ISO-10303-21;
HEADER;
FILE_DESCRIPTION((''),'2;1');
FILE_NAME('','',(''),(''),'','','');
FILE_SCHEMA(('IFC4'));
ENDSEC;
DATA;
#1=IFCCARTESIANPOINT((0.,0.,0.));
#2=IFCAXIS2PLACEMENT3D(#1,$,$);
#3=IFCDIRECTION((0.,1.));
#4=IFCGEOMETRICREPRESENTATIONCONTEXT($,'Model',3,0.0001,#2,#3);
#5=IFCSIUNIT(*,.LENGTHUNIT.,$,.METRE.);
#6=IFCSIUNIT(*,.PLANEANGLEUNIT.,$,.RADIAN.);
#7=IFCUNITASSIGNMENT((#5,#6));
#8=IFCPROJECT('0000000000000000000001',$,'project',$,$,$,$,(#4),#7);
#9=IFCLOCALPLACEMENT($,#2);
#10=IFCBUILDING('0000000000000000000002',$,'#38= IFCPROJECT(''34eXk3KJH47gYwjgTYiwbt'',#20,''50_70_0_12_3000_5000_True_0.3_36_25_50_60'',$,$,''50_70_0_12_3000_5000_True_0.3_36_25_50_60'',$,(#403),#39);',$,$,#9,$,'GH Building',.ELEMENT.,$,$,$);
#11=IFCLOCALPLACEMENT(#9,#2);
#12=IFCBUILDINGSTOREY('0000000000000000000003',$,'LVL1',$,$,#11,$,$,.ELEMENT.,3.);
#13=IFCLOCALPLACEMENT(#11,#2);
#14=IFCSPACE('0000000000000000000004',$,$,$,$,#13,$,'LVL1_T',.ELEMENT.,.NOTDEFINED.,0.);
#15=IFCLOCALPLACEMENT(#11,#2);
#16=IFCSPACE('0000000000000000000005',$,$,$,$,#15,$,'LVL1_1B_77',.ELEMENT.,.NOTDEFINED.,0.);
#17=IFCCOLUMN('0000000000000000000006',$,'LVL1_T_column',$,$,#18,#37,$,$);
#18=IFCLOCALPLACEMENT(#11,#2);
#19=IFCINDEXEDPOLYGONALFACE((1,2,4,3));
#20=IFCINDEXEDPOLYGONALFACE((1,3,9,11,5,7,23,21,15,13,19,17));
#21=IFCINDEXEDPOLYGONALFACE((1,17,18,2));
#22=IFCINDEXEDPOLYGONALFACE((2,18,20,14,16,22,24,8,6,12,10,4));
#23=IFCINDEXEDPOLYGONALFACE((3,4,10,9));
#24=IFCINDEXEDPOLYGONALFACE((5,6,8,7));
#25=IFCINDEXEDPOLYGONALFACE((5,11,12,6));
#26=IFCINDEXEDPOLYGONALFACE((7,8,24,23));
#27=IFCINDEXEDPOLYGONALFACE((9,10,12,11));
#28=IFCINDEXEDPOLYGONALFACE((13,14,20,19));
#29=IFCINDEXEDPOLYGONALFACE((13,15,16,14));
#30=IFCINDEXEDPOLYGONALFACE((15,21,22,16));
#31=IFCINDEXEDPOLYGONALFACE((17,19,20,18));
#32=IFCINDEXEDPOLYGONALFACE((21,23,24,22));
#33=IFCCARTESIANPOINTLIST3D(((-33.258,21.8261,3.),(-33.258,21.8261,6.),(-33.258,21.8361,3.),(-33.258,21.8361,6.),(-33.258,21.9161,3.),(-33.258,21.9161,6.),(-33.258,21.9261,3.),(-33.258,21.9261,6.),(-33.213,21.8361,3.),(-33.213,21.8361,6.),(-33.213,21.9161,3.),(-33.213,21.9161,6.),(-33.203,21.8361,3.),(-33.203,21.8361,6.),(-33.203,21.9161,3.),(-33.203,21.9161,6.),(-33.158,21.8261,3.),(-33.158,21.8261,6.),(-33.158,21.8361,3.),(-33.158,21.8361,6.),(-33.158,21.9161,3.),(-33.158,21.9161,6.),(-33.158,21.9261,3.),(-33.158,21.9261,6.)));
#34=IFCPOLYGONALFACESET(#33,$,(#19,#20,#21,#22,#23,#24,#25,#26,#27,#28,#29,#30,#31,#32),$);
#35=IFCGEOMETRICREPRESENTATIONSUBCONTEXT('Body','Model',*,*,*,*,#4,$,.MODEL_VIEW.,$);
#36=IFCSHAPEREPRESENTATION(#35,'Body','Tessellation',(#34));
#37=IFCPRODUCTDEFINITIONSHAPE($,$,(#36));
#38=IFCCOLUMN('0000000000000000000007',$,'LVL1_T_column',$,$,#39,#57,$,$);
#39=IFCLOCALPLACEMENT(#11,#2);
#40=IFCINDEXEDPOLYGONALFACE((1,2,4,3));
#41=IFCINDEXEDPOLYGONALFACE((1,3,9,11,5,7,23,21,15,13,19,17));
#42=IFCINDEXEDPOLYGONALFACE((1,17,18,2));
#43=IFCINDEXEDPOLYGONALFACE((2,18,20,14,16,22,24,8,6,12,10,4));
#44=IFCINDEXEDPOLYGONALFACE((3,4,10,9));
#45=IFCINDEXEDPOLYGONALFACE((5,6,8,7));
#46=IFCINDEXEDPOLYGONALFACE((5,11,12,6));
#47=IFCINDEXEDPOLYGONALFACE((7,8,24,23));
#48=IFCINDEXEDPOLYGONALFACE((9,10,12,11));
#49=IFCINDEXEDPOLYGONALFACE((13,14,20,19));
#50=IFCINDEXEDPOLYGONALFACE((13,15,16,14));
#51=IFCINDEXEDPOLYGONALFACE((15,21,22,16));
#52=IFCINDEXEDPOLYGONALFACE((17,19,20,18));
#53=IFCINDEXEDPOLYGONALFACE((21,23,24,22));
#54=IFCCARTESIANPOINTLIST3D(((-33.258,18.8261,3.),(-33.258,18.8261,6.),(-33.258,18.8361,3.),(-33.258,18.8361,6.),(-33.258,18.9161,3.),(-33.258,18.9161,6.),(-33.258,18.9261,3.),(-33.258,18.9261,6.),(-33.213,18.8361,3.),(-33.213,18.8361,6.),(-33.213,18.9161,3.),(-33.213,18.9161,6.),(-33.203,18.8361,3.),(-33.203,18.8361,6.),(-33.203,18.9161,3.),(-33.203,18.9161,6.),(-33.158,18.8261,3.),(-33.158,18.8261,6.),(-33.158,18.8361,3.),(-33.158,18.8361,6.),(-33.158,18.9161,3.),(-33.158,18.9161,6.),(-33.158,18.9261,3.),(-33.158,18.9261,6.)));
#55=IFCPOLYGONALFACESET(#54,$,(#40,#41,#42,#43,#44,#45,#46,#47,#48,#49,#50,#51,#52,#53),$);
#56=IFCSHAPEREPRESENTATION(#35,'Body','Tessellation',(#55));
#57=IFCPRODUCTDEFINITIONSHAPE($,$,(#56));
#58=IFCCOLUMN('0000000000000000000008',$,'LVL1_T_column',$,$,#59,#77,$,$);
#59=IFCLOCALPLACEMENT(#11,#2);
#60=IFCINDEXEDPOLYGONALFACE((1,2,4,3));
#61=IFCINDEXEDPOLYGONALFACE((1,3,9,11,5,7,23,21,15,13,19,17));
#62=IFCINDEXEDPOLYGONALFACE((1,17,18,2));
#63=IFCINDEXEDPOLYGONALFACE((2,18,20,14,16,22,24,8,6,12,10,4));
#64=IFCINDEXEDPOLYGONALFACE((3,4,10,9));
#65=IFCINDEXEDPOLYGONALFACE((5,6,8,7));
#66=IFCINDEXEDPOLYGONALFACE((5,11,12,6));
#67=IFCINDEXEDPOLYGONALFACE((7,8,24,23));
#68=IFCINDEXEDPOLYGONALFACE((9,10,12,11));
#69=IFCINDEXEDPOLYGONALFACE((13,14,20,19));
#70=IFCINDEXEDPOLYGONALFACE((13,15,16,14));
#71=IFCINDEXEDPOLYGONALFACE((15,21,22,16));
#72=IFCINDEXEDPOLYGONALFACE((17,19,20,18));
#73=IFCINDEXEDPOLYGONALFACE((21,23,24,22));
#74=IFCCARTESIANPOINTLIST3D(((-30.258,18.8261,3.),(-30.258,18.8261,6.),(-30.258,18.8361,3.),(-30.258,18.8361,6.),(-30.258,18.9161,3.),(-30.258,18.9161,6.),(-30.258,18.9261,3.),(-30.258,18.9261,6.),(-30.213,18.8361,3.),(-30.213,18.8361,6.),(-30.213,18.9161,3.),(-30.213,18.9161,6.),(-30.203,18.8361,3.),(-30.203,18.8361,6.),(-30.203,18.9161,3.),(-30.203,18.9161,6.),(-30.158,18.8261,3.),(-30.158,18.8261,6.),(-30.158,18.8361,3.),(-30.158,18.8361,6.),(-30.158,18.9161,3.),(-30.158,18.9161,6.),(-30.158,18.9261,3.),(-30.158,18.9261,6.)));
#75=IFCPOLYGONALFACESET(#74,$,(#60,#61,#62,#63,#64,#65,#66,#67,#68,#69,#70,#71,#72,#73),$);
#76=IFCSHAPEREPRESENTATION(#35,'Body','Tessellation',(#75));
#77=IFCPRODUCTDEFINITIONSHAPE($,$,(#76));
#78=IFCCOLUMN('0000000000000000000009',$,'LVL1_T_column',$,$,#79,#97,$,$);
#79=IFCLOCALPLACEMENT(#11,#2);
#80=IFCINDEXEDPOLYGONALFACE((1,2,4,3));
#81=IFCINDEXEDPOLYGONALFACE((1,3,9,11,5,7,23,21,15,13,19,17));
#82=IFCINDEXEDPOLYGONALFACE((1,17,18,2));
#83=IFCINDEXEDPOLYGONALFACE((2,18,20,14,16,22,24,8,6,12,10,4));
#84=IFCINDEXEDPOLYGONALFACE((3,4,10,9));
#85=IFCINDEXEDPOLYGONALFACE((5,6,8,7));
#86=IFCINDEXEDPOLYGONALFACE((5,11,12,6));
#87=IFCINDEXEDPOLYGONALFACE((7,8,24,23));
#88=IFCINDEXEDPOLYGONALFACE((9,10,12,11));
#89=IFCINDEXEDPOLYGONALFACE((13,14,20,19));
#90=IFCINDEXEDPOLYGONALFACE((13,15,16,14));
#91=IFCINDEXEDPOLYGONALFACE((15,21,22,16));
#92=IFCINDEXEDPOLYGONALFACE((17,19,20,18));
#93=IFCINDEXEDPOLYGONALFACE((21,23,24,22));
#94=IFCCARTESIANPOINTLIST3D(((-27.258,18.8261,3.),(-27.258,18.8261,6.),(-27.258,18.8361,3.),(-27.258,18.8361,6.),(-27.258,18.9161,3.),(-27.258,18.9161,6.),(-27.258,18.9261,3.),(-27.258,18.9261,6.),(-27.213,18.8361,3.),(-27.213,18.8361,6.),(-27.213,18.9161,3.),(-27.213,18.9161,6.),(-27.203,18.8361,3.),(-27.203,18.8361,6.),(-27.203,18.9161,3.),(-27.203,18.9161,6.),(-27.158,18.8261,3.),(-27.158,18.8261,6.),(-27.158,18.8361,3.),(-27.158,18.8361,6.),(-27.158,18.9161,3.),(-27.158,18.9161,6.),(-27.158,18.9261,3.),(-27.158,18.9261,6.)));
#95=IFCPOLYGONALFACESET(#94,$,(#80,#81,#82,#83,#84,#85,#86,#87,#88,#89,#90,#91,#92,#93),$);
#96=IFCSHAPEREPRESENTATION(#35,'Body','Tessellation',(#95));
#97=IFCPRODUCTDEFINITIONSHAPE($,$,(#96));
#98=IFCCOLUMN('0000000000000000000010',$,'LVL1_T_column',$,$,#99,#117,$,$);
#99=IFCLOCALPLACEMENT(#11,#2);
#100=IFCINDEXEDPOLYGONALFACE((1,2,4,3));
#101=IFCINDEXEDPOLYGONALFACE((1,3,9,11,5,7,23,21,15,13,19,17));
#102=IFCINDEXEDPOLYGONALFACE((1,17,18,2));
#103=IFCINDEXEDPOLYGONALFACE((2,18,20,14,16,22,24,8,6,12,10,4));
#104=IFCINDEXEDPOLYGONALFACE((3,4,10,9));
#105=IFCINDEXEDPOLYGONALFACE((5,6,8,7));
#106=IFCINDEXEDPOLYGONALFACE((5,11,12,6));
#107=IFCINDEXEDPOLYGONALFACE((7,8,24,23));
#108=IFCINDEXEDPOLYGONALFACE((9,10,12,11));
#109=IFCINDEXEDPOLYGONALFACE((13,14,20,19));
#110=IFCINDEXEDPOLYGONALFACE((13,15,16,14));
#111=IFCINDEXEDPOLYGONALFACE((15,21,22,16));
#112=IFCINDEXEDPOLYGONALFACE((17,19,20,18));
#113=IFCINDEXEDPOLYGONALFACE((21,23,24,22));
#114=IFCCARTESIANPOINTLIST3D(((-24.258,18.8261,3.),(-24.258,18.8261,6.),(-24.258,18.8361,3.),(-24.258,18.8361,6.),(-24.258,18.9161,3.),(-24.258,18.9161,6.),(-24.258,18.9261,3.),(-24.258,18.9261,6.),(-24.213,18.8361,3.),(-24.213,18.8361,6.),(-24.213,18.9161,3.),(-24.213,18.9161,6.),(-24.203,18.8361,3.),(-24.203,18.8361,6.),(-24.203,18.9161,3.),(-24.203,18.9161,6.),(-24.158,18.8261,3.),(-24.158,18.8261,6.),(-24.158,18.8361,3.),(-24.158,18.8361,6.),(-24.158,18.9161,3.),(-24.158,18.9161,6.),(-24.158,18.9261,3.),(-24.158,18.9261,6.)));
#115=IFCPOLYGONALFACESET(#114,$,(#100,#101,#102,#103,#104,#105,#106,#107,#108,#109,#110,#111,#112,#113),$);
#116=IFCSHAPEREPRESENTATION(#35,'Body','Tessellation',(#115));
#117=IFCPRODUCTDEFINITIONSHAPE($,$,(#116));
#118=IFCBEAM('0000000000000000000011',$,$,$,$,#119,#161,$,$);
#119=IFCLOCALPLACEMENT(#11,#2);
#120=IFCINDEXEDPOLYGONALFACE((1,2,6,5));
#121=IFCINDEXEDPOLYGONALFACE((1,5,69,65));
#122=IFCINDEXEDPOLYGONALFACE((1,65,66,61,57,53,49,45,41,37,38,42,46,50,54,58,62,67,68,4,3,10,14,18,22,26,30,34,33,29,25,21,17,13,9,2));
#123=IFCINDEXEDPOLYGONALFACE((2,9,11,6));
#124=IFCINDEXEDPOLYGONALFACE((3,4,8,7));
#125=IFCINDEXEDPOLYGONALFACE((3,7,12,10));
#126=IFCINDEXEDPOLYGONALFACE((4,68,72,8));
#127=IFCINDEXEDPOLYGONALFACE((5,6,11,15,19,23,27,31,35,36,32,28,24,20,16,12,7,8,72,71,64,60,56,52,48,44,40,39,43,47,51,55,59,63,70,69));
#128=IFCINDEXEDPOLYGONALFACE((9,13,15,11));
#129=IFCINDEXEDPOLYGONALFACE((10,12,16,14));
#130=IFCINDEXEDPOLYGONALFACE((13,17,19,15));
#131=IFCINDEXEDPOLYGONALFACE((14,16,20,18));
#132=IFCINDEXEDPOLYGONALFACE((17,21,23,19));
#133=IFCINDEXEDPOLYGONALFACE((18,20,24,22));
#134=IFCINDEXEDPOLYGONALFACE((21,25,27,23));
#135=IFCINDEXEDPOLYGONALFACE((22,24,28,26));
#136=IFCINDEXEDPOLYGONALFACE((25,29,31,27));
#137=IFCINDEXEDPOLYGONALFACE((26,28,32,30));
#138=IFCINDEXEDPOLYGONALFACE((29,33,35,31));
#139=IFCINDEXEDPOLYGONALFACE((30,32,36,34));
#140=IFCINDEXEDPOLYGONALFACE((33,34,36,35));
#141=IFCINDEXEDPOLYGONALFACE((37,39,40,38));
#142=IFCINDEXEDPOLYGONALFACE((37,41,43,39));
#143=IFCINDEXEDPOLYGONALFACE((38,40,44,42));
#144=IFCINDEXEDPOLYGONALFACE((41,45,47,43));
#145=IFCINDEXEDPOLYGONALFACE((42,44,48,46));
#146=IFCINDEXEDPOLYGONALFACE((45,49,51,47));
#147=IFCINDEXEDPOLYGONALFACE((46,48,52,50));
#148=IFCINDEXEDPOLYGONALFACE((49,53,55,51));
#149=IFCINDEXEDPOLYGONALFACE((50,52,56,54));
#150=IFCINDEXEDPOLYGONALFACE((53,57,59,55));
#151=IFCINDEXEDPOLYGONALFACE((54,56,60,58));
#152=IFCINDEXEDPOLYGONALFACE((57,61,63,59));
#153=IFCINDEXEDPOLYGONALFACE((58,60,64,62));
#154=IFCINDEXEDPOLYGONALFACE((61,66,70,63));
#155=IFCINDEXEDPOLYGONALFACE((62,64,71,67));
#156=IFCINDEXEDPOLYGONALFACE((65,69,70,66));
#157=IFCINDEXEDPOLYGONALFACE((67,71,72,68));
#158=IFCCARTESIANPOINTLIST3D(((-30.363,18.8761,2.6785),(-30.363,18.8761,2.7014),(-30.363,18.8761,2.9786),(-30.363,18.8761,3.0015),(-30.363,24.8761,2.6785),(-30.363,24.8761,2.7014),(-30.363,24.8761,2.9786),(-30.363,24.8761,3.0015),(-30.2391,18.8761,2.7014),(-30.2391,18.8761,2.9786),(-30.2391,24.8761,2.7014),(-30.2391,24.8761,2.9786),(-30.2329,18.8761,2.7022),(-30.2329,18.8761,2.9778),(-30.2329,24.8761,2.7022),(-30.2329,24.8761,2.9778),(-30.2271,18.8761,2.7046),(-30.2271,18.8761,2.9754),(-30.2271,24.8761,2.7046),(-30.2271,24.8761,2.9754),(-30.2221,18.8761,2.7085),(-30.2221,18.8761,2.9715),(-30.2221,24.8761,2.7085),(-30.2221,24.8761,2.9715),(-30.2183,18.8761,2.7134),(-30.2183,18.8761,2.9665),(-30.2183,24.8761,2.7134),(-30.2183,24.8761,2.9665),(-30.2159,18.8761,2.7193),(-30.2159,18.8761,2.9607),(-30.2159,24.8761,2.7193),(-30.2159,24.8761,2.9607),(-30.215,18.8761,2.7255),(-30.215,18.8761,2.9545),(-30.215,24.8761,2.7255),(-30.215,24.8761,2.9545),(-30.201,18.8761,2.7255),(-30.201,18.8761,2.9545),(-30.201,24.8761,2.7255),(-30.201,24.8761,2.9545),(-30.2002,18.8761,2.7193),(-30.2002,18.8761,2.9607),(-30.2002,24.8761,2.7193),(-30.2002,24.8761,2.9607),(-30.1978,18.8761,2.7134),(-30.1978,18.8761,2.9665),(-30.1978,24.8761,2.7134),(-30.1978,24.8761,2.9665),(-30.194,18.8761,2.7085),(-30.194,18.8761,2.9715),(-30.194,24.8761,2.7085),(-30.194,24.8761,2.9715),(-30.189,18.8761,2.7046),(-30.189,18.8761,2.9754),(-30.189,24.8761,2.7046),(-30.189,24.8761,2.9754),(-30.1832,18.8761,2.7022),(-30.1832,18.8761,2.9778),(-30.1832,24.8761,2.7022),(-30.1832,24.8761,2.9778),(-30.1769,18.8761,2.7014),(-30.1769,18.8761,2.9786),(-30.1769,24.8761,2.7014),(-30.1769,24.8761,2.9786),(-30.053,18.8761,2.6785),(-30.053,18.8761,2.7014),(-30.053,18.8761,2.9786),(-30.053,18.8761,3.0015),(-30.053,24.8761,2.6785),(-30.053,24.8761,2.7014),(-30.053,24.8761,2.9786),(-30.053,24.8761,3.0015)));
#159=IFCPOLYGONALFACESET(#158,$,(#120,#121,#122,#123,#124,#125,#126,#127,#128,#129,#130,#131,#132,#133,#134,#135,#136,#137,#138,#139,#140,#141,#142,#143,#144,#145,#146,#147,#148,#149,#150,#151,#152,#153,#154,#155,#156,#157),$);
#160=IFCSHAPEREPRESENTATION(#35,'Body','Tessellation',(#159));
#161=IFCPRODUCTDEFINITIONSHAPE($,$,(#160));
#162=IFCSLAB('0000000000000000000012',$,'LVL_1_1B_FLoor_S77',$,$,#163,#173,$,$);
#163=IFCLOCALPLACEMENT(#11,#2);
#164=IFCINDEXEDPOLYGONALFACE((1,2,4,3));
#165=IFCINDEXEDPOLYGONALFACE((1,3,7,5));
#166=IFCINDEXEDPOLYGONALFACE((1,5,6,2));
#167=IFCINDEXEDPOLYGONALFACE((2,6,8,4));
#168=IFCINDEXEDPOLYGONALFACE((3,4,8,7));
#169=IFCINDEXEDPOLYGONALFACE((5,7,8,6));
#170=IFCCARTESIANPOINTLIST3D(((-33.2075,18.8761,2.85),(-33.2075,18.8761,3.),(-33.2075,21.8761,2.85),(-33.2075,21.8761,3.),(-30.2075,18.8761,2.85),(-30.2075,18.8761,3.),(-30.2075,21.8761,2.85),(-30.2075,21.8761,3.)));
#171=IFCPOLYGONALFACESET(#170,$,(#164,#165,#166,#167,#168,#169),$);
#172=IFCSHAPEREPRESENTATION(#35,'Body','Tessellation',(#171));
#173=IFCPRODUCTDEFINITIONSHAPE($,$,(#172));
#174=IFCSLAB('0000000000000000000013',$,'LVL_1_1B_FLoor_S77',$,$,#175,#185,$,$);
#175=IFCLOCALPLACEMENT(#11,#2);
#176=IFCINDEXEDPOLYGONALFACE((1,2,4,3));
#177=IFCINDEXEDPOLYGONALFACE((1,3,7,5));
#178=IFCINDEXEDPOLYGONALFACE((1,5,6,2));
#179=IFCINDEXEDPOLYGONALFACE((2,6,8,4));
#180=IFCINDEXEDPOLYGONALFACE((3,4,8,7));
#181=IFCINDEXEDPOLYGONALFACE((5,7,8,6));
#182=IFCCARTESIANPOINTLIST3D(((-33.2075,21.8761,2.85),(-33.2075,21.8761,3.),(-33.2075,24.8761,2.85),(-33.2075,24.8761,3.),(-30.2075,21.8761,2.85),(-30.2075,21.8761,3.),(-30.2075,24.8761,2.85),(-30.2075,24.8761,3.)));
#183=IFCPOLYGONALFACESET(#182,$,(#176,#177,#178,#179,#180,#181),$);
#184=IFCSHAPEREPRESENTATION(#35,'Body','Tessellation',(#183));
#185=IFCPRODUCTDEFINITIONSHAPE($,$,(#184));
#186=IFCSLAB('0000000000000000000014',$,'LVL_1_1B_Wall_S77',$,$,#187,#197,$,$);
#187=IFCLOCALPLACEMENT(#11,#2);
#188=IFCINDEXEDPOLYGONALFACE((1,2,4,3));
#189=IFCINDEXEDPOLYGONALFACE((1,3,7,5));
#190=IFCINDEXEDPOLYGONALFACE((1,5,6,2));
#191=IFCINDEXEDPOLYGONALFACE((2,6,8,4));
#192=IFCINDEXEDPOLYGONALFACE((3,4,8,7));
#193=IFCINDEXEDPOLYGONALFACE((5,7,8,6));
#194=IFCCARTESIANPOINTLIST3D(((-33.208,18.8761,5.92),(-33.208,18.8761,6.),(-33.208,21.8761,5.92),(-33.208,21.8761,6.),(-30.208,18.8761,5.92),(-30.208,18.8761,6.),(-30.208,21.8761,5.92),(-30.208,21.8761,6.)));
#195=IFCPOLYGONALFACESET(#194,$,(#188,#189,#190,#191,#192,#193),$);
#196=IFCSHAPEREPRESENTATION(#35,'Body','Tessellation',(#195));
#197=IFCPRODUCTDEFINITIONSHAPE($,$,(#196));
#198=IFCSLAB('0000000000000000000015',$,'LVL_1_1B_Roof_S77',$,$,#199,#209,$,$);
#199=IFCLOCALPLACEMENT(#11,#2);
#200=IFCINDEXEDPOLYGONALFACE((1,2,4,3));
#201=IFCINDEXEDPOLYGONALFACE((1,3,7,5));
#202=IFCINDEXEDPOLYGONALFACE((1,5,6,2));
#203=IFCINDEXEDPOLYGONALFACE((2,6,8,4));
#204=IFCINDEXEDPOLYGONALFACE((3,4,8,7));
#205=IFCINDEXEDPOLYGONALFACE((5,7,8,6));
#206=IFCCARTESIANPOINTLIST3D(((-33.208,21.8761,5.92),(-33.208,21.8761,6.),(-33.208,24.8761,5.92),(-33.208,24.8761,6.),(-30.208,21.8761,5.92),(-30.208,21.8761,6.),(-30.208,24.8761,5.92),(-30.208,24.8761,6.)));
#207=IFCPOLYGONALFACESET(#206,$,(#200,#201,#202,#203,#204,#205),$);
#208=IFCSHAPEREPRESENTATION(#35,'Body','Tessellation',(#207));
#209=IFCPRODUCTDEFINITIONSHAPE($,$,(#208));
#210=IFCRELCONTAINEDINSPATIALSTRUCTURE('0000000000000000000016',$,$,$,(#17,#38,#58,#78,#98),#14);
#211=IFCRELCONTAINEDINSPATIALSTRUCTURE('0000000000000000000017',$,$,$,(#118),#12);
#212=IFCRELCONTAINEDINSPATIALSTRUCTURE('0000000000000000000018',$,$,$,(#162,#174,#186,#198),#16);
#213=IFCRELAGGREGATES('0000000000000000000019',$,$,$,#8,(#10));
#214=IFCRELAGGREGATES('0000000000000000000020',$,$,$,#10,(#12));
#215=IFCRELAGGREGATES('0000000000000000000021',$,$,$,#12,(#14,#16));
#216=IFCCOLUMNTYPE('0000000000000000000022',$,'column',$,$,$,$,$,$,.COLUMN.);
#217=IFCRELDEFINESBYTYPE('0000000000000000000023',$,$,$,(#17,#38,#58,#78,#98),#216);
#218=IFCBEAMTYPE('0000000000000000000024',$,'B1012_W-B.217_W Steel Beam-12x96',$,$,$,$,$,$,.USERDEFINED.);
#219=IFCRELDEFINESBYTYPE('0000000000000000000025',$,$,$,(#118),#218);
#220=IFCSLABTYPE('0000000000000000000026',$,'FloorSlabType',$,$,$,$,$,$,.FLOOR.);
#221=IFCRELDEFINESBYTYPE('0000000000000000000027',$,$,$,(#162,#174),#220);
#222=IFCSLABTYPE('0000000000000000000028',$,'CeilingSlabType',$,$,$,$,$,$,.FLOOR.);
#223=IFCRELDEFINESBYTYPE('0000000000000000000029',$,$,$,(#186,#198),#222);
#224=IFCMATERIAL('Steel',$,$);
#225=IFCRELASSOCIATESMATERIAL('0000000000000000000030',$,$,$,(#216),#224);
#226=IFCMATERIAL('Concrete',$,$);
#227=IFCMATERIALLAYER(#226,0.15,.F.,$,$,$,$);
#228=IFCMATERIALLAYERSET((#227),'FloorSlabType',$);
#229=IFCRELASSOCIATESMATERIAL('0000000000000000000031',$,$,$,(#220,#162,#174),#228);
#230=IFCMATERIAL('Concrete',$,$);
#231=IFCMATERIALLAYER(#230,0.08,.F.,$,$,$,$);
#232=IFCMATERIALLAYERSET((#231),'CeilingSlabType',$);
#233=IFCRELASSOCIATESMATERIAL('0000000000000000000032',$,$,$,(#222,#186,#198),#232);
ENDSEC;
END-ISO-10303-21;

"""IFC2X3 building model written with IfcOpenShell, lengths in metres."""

from ifc_helpers import new_model, si_unit, direction, frame, frame_2d, origin, origin_2d, place, context, subcontext, project, spatial, rectangle, i_section, extrude, material, layer, layer_set, layer_usage, type_object, element, save


model = new_model("IFC2X3")

# Units and contexts
model_context = context("Model", 3, precision=0.0001, world=origin(), true_north=direction((0.0, 1.0)))
body_context = subcontext(model_context, "Body", "Model", "MODEL_VIEW")
ifc_project = project(units=[si_unit("LENGTHUNIT", "METRE"), si_unit("PLANEANGLEUNIT", "RADIAN")], contexts=[model_context])

# Building, storey, space
building_placement = place(None, origin())
building = spatial("IfcBuilding", under=ifc_project, at=building_placement, Name="#38= IFCPROJECT('34eXk3KJH47gYwjgTYiwbt',#20,'50_70_0_12_3000_5000_True_0.3_36_25_50_60',$,$,'50_70_0_12_3000_5000_True_0.3_36_25_50_60',$,(#403),#39);", LongName="GH Building", CompositionType="ELEMENT")
storey_placement = place(building_placement, origin())
storey = spatial("IfcBuildingStorey", under=building, at=storey_placement, Name="LVL1", CompositionType="ELEMENT", Elevation=3.0)
space_1_placement = place(storey_placement, origin())
space_1 = spatial("IfcSpace", under=storey, at=space_1_placement, LongName="LVL1_T", CompositionType="ELEMENT", InteriorOrExteriorSpace="NOTDEFINED", ElevationWithFlooring=0.0)

# Columns
ifc_material_1 = material(Name="Steel")
column_type = type_object("IfcColumnType", Name="column", PredefinedType="COLUMN", material=ifc_material_1)
for number, where, name in (
    (1, (-33.208, 21.8761, 3.0), "LVL1_T_column"),
    (2, (-33.208, 18.8761, 3.0), "LVL1_T_column"),
    (3, (-30.208, 18.8761, 3.0), "LVL1_T_column"),
    (4, (-27.208, 18.8761, 3.0), "LVL1_T_column"),
    (5, (-24.208, 18.8761, 3.0), "LVL1_T_column"),
):
    element("IfcColumn", number, at=place(space_1_placement, frame(where)), inside=space_1, type_object=column_type, Name=name, context=body_context, shape_type="SweptSolid", body=[
        extrude(i_section(OverallWidth=0.1, OverallDepth=0.1, WebThickness=0.01, FlangeThickness=0.01, at=origin_2d()), origin(), (0.0, 0.0, 1.0), 3.0),
    ])

# Beam
beam_type = type_object("IfcBeamType", Name="B1012_W-B.217_W Steel Beam-12x96", PredefinedType="USERDEFINED")
beam_placement = place(storey_placement, frame((-30.208, 18.8761, 2.84), z_axis=(0.0, 1.0, 0.0), x_axis=(-1.0, 0.0, 0.0)))
element("IfcBeam", 6, at=beam_placement, inside=storey, type_object=beam_type, context=body_context, shape_type="SweptSolid", body=[
    extrude(i_section(OverallWidth=0.31, OverallDepth=0.323, WebThickness=0.014, FlangeThickness=0.0229, FilletRadius=0.0241, at=origin_2d()), origin(), (0.0, 0.0, 1.0), 6.0),
])

# Shared definitions
space_2_placement = place(storey_placement, origin())
space_2 = spatial("IfcSpace", under=storey, at=space_2_placement, LongName="LVL1_1B_77", CompositionType="ELEMENT", InteriorOrExteriorSpace="NOTDEFINED", ElevationWithFlooring=0.0)

# Slabs
ifc_material_2 = material(Name="Concrete")
ifc_layer_1 = layer(ifc_material_2, 0.15, ventilated=False)
ifc_layer_set_1 = layer_set([ifc_layer_1], Name="FloorSlabType")
ifc_layer_usage_1 = layer_usage(ifc_layer_set_1, "AXIS3", "NEGATIVE", -0.15)
slab_type_1 = type_object("IfcSlabType", Name="FloorSlabType", PredefinedType="FLOOR", material=ifc_layer_set_1)
slab_1_placement = place(space_2_placement, frame((-30.2075, 18.8761, 2.85), z_axis=(0.0, 0.0, 1.0), x_axis=(0.0, 1.0, 0.0)))
element("IfcSlab", 7, at=slab_1_placement, inside=space_2, type_object=slab_type_1, material=ifc_layer_usage_1, Name="LVL_1_1B_FLoor_S77", context=body_context, shape_type="SweptSolid", body=[
    extrude(rectangle(XDim=3.0, YDim=3.0, at=frame_2d((1.5, 1.5))), origin(), (0.0, 0.0, 1.0), 0.15),
])
ifc_layer_usage_2 = layer_usage(ifc_layer_set_1, "AXIS3", "NEGATIVE", -0.15)
slab_2_placement = place(space_2_placement, frame((-30.2075, 21.8761, 2.85), z_axis=(0.0, 0.0, 1.0), x_axis=(0.0, 1.0, 0.0)))
element("IfcSlab", 8, at=slab_2_placement, inside=space_2, type_object=slab_type_1, material=ifc_layer_usage_2, Name="LVL_1_1B_FLoor_S77", context=body_context, shape_type="SweptSolid", body=[
    extrude(rectangle(XDim=3.0, YDim=3.0, at=frame_2d((1.5, 1.5))), origin(), (0.0, 0.0, 1.0), 0.15),
])
ifc_material_3 = material(Name="Concrete")
ifc_layer_2 = layer(ifc_material_3, 0.08, ventilated=False)
ifc_layer_set_2 = layer_set([ifc_layer_2], Name="CeilingSlabType")
ifc_layer_usage_3 = layer_usage(ifc_layer_set_2, "AXIS3", "NEGATIVE", -0.08)
slab_type_2 = type_object("IfcSlabType", Name="CeilingSlabType", PredefinedType="FLOOR", material=ifc_layer_set_2)
slab_3_placement = place(space_2_placement, frame((-30.208, 18.8761, 5.92), z_axis=(0.0, 0.0, 1.0), x_axis=(0.0, 1.0, 0.0)))
element("IfcSlab", 9, at=slab_3_placement, inside=space_2, type_object=slab_type_2, material=ifc_layer_usage_3, Name="LVL_1_1B_Wall_S77", context=body_context, shape_type="SweptSolid", body=[
    extrude(rectangle(XDim=3.0, YDim=3.0, at=frame_2d((1.5, 1.5))), origin(), (0.0, 0.0, 1.0), 0.08),
])
ifc_layer_usage_4 = layer_usage(ifc_layer_set_2, "AXIS3", "NEGATIVE", -0.08)
slab_4_placement = place(space_2_placement, frame((-30.208, 21.8761, 5.92), z_axis=(0.0, 0.0, 1.0), x_axis=(0.0, 1.0, 0.0)))
element("IfcSlab", 10, at=slab_4_placement, inside=space_2, type_object=slab_type_2, material=ifc_layer_usage_4, Name="LVL_1_1B_Roof_S77", context=body_context, shape_type="SweptSolid", body=[
    extrude(rectangle(XDim=3.0, YDim=3.0, at=frame_2d((1.5, 1.5))), origin(), (0.0, 0.0, 1.0), 0.08),
])

save(model, "model.ifc")
